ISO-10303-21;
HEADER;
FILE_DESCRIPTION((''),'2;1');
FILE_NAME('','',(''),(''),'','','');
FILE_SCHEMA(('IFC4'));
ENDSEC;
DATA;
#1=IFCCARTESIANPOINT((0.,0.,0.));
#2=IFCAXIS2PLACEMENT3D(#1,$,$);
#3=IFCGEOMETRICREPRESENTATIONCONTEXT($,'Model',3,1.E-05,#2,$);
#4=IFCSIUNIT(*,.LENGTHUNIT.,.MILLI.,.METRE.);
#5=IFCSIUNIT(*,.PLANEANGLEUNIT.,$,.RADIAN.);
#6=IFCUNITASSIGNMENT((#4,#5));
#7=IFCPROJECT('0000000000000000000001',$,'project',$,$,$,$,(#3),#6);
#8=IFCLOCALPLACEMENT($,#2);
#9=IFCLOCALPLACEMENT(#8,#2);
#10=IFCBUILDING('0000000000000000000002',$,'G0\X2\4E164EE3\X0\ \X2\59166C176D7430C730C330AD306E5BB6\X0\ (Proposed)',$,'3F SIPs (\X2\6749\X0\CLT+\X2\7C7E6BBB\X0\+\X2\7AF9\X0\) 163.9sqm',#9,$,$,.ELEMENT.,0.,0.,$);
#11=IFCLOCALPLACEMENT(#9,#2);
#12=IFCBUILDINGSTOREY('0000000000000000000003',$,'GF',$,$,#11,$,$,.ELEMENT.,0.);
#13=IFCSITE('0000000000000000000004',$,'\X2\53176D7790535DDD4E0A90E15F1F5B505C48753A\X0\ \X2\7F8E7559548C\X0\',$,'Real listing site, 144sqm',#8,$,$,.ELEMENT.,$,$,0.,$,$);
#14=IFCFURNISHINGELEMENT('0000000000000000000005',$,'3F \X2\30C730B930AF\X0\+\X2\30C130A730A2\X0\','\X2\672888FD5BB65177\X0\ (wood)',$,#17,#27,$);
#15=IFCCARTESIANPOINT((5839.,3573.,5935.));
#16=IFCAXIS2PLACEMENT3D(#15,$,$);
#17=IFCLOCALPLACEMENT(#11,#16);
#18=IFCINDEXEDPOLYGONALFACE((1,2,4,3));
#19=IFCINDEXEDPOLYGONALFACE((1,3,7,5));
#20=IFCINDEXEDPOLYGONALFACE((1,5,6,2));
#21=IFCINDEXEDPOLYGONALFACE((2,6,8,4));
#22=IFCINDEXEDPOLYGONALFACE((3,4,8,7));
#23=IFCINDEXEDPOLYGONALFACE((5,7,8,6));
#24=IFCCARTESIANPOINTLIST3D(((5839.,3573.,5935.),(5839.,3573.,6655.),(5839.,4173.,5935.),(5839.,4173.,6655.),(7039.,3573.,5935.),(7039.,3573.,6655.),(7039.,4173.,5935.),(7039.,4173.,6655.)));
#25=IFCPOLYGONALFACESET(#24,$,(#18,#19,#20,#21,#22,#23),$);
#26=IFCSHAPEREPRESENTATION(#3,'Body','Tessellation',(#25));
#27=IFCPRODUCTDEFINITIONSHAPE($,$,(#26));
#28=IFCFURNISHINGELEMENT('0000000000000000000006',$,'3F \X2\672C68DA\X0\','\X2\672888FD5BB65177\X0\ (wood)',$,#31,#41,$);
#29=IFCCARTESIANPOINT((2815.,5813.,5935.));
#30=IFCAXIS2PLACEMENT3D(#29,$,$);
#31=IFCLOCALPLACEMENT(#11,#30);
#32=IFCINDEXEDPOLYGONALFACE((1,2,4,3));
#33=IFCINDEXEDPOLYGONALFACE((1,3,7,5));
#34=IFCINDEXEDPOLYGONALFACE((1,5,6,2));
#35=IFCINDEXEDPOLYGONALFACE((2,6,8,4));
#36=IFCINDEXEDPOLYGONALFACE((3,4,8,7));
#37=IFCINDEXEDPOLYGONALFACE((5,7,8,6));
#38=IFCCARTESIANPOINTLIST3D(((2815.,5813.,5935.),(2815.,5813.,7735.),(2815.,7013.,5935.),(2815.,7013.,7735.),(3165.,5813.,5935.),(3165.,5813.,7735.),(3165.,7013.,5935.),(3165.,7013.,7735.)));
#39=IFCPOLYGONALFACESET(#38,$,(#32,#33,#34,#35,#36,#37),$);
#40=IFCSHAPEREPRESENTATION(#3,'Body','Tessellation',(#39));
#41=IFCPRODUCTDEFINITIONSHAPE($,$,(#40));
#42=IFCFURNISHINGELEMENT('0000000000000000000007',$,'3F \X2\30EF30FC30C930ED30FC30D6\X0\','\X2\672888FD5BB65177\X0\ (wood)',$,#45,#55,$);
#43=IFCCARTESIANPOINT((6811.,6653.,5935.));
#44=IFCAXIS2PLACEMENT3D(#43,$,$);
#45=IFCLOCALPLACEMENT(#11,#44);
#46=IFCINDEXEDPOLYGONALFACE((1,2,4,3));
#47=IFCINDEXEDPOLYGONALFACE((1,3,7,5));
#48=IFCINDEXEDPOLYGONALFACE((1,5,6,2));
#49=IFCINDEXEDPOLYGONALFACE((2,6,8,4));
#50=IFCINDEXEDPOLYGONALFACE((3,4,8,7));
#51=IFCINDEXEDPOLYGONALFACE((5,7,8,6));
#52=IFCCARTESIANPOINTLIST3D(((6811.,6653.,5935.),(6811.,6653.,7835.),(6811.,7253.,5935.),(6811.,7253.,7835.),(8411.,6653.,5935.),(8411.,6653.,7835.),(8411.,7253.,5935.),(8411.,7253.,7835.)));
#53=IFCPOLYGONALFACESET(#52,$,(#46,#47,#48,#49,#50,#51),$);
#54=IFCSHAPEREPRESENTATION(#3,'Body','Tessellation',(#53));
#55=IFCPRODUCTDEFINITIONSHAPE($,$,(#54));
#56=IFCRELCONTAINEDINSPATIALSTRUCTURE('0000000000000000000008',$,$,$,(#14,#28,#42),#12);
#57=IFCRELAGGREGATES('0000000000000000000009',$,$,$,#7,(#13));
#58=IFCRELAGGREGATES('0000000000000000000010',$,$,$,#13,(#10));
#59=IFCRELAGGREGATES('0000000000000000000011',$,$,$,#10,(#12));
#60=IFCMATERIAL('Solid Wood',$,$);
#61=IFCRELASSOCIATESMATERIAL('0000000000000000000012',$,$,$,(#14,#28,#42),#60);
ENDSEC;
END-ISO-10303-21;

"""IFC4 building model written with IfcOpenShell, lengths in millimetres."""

from ifc_helpers import new_model, si_unit, frame, frame_2d, origin, place, context, project, spatial, rectangle, extrude, material, element, save


model = new_model("IFC4")

# Units and contexts
model_context = context("Model", 3, precision=1e-05, world=origin())
ifc_project = project(units=[si_unit("LENGTHUNIT", "METRE", prefix="MILLI"), si_unit("PLANEANGLEUNIT", "RADIAN")], contexts=[model_context])

# Site, building, storey
site_placement = place(None, origin())
site = spatial("IfcSite", under=ifc_project, at=site_placement, Name="北海道川上郡弟子屈町 美留和", ObjectType="Real listing site, 144sqm", CompositionType="ELEMENT", RefElevation=0.0)
building_placement = place(site_placement, origin())
building = spatial("IfcBuilding", under=site, at=building_placement, Name="G0世代 外気浴デッキの家 (Proposed)", ObjectType="3F SIPs (杉CLT+籾殻+竹) 163.9sqm", CompositionType="ELEMENT", ElevationOfRefHeight=0.0, ElevationOfTerrain=0.0)
storey_placement = place(building_placement, origin())
storey = spatial("IfcBuildingStorey", under=building, at=storey_placement, Name="GF", CompositionType="ELEMENT", Elevation=0.0)

# Shared definitions
ifc_material_1 = material(Name="Solid Wood")

# Furnishing elements
furnishing_1_placement = place(storey_placement, frame((5839.0, 3573.0, 5935.0)))
element("IfcFurnishingElement", 1, at=furnishing_1_placement, inside=storey, material=ifc_material_1, Name="3F デスク+チェア", Description="木製家具 (wood)", context=model_context, shape_type="SweptSolid", body=[
    extrude(rectangle(XDim=1200.0, YDim=600.0, at=frame_2d((600.0, 300.0))), frame((5839.0, 3573.0, 5935.0)), (0.0, 0.0, 1.0), 720.0),
])
furnishing_2_placement = place(storey_placement, frame((2815.0, 5813.0, 5935.0)))
element("IfcFurnishingElement", 2, at=furnishing_2_placement, inside=storey, material=ifc_material_1, Name="3F 本棚", Description="木製家具 (wood)", context=model_context, shape_type="SweptSolid", body=[
    extrude(rectangle(XDim=350.0, YDim=1200.0, at=frame_2d((175.0, 600.0))), frame((2815.0, 5813.0, 5935.0)), (0.0, 0.0, 1.0), 1800.0),
])
furnishing_3_placement = place(storey_placement, frame((6811.0, 6653.0, 5935.0)))
element("IfcFurnishingElement", 3, at=furnishing_3_placement, inside=storey, material=ifc_material_1, Name="3F ワードローブ", Description="木製家具 (wood)", context=model_context, shape_type="SweptSolid", body=[
    extrude(rectangle(XDim=1600.0, YDim=600.0, at=frame_2d((800.0, 300.0))), frame((6811.0, 6653.0, 5935.0)), (0.0, 0.0, 1.0), 1900.0),
])

save(model, "model.ifc")
